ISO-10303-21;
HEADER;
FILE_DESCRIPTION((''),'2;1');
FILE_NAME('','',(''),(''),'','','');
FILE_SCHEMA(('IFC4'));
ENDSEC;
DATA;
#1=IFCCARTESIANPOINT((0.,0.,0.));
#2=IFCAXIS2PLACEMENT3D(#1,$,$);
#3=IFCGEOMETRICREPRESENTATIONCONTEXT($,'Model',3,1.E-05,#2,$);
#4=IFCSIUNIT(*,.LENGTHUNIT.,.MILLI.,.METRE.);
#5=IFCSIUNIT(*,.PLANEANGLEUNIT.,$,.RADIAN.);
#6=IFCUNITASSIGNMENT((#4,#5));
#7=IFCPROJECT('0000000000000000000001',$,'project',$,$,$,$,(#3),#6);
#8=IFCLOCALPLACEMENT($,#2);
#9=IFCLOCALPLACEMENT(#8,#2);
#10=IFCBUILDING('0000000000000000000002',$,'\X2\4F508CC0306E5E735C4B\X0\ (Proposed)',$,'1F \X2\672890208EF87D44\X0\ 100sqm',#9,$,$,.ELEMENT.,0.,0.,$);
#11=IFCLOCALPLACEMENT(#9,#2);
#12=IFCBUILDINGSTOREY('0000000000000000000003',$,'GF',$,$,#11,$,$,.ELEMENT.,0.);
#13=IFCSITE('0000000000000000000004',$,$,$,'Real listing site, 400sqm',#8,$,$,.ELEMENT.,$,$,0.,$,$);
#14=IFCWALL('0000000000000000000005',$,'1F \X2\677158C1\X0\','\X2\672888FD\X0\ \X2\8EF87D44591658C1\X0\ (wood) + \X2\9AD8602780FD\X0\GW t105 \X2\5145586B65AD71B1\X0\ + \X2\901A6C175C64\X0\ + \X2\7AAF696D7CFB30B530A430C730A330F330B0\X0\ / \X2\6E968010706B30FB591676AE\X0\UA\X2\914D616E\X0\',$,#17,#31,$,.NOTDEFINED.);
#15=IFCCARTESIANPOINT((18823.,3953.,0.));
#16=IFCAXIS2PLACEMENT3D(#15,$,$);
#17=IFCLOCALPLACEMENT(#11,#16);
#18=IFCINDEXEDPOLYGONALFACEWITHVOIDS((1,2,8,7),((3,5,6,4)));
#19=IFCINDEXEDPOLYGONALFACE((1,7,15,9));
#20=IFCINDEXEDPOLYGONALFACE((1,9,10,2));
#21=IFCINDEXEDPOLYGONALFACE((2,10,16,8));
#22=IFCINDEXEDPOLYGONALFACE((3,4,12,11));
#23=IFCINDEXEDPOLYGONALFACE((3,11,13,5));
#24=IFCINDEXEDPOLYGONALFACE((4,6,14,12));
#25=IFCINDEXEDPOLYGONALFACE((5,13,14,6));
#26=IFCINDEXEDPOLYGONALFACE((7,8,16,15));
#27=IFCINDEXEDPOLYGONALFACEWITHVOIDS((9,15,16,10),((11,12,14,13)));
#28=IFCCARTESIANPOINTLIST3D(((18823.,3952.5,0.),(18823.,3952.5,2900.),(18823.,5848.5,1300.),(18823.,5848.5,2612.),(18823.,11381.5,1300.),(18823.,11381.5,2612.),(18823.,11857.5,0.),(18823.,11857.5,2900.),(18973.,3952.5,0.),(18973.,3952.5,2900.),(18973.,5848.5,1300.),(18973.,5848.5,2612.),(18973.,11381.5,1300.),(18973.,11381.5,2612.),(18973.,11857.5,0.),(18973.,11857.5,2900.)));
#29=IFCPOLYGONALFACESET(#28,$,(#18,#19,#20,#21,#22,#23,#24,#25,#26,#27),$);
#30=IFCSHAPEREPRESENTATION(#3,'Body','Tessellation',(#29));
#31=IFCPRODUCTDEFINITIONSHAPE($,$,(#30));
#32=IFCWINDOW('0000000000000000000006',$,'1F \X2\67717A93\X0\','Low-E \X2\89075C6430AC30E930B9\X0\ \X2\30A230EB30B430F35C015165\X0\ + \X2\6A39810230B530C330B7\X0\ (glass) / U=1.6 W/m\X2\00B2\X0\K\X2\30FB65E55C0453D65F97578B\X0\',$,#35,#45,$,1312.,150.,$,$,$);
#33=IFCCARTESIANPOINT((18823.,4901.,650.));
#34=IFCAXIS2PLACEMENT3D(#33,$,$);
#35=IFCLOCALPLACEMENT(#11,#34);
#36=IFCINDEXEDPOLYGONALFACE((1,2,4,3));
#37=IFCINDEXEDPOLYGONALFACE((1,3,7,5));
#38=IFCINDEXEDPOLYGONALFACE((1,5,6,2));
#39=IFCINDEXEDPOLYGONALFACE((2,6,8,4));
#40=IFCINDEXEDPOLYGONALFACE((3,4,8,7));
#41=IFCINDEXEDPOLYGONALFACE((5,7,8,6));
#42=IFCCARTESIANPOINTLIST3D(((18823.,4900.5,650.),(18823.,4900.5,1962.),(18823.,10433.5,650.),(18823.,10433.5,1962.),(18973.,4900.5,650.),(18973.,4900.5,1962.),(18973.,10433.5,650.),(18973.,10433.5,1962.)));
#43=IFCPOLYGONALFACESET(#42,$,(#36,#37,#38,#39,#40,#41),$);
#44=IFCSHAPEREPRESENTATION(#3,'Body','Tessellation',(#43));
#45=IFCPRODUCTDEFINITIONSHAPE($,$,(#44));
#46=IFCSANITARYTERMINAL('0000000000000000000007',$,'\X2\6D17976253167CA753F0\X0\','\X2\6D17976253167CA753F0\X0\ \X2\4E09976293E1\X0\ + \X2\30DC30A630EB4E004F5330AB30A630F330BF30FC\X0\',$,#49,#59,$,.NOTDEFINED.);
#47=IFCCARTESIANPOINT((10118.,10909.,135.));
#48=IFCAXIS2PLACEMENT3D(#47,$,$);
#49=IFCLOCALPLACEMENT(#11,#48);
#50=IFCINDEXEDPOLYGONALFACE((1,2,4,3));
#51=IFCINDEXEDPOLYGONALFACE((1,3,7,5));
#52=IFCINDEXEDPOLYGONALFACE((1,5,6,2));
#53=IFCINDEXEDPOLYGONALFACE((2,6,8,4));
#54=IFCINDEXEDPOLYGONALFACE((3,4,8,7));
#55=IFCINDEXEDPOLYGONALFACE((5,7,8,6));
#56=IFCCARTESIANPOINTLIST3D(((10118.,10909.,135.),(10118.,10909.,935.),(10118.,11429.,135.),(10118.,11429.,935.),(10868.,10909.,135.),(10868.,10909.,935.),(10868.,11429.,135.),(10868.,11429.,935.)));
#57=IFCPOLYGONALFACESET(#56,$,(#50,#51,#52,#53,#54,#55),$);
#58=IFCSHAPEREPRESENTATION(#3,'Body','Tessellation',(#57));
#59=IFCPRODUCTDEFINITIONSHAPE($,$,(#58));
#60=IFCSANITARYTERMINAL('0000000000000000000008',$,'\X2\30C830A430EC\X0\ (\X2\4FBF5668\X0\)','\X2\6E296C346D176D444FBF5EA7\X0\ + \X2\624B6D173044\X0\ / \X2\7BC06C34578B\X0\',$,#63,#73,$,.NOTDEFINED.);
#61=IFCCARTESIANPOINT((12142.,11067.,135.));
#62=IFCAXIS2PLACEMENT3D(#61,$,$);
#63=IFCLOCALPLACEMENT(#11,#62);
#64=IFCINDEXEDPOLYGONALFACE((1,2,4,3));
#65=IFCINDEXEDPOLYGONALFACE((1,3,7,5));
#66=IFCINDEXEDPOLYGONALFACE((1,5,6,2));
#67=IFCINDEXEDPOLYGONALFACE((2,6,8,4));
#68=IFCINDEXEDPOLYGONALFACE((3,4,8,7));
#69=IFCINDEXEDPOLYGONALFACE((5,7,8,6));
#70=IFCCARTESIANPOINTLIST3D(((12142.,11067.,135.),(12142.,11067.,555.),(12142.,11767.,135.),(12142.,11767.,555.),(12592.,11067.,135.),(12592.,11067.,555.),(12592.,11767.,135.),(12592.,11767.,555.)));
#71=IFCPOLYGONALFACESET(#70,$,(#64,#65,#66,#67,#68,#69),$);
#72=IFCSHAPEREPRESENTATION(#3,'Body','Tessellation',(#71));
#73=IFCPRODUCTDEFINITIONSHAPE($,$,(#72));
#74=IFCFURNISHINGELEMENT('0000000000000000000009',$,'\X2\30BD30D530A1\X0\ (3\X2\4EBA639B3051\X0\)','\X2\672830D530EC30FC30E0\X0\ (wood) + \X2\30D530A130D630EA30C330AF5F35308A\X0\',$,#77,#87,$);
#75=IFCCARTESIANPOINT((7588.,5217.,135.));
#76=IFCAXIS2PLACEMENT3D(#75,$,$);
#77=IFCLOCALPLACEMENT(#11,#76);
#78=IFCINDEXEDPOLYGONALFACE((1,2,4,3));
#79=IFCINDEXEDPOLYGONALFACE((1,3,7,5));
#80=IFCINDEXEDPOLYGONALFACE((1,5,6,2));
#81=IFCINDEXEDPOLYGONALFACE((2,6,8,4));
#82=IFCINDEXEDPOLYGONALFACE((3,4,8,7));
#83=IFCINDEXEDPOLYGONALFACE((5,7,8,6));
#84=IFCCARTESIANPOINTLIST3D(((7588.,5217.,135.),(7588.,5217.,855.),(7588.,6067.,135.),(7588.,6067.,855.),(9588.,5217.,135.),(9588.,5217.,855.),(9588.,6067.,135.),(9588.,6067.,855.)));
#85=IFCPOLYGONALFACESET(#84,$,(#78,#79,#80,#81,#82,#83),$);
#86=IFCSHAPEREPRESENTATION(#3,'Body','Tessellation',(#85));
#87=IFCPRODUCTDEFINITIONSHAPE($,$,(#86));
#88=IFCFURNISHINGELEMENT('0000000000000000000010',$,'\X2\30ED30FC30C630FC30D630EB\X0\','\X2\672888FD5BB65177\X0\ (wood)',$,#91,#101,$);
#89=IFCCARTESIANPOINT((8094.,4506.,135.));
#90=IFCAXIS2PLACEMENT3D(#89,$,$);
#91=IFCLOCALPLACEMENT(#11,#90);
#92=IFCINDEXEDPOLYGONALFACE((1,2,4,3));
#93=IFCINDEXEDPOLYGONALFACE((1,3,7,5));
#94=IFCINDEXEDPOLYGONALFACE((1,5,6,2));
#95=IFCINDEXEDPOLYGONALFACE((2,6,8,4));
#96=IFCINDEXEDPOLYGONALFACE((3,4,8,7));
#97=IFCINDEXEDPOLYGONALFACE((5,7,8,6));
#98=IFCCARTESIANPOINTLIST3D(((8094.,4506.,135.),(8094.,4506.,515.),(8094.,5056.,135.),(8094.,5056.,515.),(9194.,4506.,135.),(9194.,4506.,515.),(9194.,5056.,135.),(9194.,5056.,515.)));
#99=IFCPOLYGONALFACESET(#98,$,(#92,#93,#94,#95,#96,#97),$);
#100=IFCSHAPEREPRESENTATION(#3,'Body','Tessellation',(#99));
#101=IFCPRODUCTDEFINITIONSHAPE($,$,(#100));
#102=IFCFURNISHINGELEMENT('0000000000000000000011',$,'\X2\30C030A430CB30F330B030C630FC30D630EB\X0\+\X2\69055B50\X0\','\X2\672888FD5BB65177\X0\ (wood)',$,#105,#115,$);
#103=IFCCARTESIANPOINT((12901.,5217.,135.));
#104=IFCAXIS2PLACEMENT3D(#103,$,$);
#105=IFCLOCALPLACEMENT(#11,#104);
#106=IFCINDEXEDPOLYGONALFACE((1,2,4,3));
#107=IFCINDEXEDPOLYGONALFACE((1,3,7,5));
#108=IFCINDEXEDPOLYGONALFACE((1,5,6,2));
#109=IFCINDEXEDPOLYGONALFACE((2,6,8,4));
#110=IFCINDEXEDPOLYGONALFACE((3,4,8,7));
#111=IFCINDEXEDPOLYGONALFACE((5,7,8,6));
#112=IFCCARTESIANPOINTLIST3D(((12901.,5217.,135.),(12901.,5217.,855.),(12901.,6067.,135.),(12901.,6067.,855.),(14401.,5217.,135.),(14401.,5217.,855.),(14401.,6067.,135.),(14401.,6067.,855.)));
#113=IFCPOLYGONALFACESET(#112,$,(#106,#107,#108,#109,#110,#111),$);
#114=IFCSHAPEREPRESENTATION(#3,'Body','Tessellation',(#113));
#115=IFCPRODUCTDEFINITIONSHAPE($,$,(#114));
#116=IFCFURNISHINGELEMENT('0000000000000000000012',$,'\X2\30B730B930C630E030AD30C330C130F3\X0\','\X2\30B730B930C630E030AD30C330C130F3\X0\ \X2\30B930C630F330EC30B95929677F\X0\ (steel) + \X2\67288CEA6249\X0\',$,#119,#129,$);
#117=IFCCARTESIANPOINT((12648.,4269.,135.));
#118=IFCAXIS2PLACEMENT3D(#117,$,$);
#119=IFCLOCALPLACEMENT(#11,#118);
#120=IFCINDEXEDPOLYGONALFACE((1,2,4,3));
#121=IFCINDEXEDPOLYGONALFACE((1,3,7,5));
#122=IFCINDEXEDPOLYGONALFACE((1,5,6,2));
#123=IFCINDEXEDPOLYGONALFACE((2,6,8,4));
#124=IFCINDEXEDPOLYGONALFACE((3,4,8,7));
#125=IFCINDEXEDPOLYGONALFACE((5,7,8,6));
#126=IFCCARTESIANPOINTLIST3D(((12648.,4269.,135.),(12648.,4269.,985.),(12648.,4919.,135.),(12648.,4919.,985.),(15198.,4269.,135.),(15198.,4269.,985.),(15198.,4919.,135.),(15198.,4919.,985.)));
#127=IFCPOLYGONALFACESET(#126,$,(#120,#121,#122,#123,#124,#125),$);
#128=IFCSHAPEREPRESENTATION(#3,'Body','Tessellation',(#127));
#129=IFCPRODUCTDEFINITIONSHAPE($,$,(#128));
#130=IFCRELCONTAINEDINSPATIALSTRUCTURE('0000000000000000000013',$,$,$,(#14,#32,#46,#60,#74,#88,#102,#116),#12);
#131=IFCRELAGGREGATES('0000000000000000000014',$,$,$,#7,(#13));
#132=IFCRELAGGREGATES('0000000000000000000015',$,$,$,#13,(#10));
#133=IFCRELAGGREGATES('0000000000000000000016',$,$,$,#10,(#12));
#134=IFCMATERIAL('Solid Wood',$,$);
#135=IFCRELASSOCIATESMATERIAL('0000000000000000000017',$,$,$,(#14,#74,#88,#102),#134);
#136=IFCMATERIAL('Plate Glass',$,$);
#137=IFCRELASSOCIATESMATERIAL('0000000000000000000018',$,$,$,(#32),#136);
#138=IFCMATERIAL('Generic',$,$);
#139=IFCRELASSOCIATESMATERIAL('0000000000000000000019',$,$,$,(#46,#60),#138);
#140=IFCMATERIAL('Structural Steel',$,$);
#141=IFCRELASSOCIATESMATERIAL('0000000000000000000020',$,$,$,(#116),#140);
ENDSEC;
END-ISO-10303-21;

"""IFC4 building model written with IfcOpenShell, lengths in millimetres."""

from ifc_helpers import new_model, si_unit, frame, frame_2d, origin, place, context, project, spatial, rectangle, extrude, material, element, fill, save


model = new_model("IFC4")

# Units and contexts
model_context = context("Model", 3, precision=1e-05, world=origin())
ifc_project = project(units=[si_unit("LENGTHUNIT", "METRE", prefix="MILLI"), si_unit("PLANEANGLEUNIT", "RADIAN")], contexts=[model_context])

# Site, building, storey
site_placement = place(None, origin())
site = spatial("IfcSite", under=ifc_project, at=site_placement, ObjectType="Real listing site, 400sqm", CompositionType="ELEMENT", RefElevation=0.0)
building_placement = place(site_placement, origin())
building = spatial("IfcBuilding", under=site, at=building_placement, Name="佐賀の平屋 (Proposed)", ObjectType="1F 木造軸組 100sqm", CompositionType="ELEMENT", ElevationOfRefHeight=0.0, ElevationOfTerrain=0.0)
storey_placement = place(building_placement, origin())
storey = spatial("IfcBuildingStorey", under=building, at=storey_placement, Name="GF", CompositionType="ELEMENT", Elevation=0.0)

# Shared definitions
ifc_material_1 = material(Name="Solid Wood")

# Wall, opening, window
wall_1_placement = place(storey_placement, frame((18823.0, 3953.0, 0.0)))
wall_1 = element("IfcWall", 1, at=wall_1_placement, inside=storey, material=ifc_material_1, Name="1F 東壁", Description="木製 軸組外壁 (wood) + 高性能GW t105 充填断熱 + 通気層 + 窯業系サイディング / 準耐火・外皮UA配慮", PredefinedType="NOTDEFINED", context=model_context, shape_type="SweptSolid", body=[
    extrude(rectangle(XDim=150.0, YDim=7905.0, at=frame_2d((75.0, 3952.0))), frame((18823.0, 3953.0, 0.0)), (0.0, 0.0, 1.0), 2900.0),
])
opening_1_placement = place(storey_placement, frame((18823.0, 4901.0, 650.0)))
opening_1 = element("IfcOpeningElement", 2, at=opening_1_placement, cuts=wall_1, PredefinedType="NOTDEFINED", context=model_context, shape_type="SweptSolid", body=[
    extrude(rectangle(XDim=150.0, YDim=5533.0, at=frame_2d((75.0, 2766.0))), frame((18823.0, 4901.0, 650.0)), (0.0, 0.0, 1.0), 1312.0),
])
ifc_material_2 = material(Name="Plate Glass")
window_1_placement = place(storey_placement, frame((18823.0, 4901.0, 650.0)))
window_1 = element("IfcWindow", 3, at=window_1_placement, inside=storey, material=ifc_material_2, Name="1F 東窓", Description="Low-E 複層ガラス アルゴン封入 + 樹脂サッシ (glass) / U=1.6 W/m²K・日射取得型", OverallHeight=1312.0, OverallWidth=150.0, context=model_context, shape_type="SweptSolid", body=[
    extrude(rectangle(XDim=150.0, YDim=5533.0, at=frame_2d((75.0, 2766.0))), frame((18823.0, 4901.0, 650.0)), (0.0, 0.0, 1.0), 1312.0),
])
fill(opening_1, window_1)

# Shared definitions
ifc_material_3 = material(Name="Structural Steel")

# Shared definitions
ifc_material_4 = material(Name="Generic")

# Sanitary terminals
sanitary_terminal_1_placement = place(storey_placement, frame((10118.0, 10909.0, 135.0)))
element("IfcSanitaryTerminal", 4, at=sanitary_terminal_1_placement, inside=storey, material=ifc_material_4, Name="洗面化粧台", Description="洗面化粧台 三面鏡 + ボウル一体カウンター", PredefinedType="NOTDEFINED", context=model_context, shape_type="SweptSolid", body=[
    extrude(rectangle(XDim=750.0, YDim=520.0, at=frame_2d((375.0, 260.0))), frame((10118.0, 10909.0, 135.0)), (0.0, 0.0, 1.0), 800.0),
])
sanitary_terminal_2_placement = place(storey_placement, frame((12142.0, 11067.0, 135.0)))
element("IfcSanitaryTerminal", 5, at=sanitary_terminal_2_placement, inside=storey, material=ifc_material_4, Name="トイレ (便器)", Description="温水洗浄便座 + 手洗い / 節水型", PredefinedType="NOTDEFINED", context=model_context, shape_type="SweptSolid", body=[
    extrude(rectangle(XDim=450.0, YDim=700.0, at=frame_2d((225.0, 350.0))), frame((12142.0, 11067.0, 135.0)), (0.0, 0.0, 1.0), 420.0),
])

# Furnishing elements
furnishing_1_placement = place(storey_placement, frame((7588.0, 5217.0, 135.0)))
element("IfcFurnishingElement", 6, at=furnishing_1_placement, inside=storey, material=ifc_material_1, Name="ソファ (3人掛け)", Description="木フレーム (wood) + ファブリック張り", context=model_context, shape_type="SweptSolid", body=[
    extrude(rectangle(XDim=2000.0, YDim=850.0, at=frame_2d((1000.0, 425.0))), frame((7588.0, 5217.0, 135.0)), (0.0, 0.0, 1.0), 720.0),
])
furnishing_2_placement = place(storey_placement, frame((8094.0, 4506.0, 135.0)))
element("IfcFurnishingElement", 7, at=furnishing_2_placement, inside=storey, material=ifc_material_1, Name="ローテーブル", Description="木製家具 (wood)", context=model_context, shape_type="SweptSolid", body=[
    extrude(rectangle(XDim=1100.0, YDim=550.0, at=frame_2d((550.0, 275.0))), frame((8094.0, 4506.0, 135.0)), (0.0, 0.0, 1.0), 380.0),
])
furnishing_3_placement = place(storey_placement, frame((12901.0, 5217.0, 135.0)))
element("IfcFurnishingElement", 8, at=furnishing_3_placement, inside=storey, material=ifc_material_1, Name="ダイニングテーブル+椅子", Description="木製家具 (wood)", context=model_context, shape_type="SweptSolid", body=[
    extrude(rectangle(XDim=1500.0, YDim=850.0, at=frame_2d((750.0, 425.0))), frame((12901.0, 5217.0, 135.0)), (0.0, 0.0, 1.0), 720.0),
])
furnishing_4_placement = place(storey_placement, frame((12648.0, 4269.0, 135.0)))
element("IfcFurnishingElement", 9, at=furnishing_4_placement, inside=storey, material=ifc_material_3, Name="システムキッチン", Description="システムキッチン ステンレス天板 (steel) + 木質扉", context=model_context, shape_type="SweptSolid", body=[
    extrude(rectangle(XDim=2550.0, YDim=650.0, at=frame_2d((1275.0, 325.0))), frame((12648.0, 4269.0, 135.0)), (0.0, 0.0, 1.0), 850.0),
])

save(model, "model.ifc")
